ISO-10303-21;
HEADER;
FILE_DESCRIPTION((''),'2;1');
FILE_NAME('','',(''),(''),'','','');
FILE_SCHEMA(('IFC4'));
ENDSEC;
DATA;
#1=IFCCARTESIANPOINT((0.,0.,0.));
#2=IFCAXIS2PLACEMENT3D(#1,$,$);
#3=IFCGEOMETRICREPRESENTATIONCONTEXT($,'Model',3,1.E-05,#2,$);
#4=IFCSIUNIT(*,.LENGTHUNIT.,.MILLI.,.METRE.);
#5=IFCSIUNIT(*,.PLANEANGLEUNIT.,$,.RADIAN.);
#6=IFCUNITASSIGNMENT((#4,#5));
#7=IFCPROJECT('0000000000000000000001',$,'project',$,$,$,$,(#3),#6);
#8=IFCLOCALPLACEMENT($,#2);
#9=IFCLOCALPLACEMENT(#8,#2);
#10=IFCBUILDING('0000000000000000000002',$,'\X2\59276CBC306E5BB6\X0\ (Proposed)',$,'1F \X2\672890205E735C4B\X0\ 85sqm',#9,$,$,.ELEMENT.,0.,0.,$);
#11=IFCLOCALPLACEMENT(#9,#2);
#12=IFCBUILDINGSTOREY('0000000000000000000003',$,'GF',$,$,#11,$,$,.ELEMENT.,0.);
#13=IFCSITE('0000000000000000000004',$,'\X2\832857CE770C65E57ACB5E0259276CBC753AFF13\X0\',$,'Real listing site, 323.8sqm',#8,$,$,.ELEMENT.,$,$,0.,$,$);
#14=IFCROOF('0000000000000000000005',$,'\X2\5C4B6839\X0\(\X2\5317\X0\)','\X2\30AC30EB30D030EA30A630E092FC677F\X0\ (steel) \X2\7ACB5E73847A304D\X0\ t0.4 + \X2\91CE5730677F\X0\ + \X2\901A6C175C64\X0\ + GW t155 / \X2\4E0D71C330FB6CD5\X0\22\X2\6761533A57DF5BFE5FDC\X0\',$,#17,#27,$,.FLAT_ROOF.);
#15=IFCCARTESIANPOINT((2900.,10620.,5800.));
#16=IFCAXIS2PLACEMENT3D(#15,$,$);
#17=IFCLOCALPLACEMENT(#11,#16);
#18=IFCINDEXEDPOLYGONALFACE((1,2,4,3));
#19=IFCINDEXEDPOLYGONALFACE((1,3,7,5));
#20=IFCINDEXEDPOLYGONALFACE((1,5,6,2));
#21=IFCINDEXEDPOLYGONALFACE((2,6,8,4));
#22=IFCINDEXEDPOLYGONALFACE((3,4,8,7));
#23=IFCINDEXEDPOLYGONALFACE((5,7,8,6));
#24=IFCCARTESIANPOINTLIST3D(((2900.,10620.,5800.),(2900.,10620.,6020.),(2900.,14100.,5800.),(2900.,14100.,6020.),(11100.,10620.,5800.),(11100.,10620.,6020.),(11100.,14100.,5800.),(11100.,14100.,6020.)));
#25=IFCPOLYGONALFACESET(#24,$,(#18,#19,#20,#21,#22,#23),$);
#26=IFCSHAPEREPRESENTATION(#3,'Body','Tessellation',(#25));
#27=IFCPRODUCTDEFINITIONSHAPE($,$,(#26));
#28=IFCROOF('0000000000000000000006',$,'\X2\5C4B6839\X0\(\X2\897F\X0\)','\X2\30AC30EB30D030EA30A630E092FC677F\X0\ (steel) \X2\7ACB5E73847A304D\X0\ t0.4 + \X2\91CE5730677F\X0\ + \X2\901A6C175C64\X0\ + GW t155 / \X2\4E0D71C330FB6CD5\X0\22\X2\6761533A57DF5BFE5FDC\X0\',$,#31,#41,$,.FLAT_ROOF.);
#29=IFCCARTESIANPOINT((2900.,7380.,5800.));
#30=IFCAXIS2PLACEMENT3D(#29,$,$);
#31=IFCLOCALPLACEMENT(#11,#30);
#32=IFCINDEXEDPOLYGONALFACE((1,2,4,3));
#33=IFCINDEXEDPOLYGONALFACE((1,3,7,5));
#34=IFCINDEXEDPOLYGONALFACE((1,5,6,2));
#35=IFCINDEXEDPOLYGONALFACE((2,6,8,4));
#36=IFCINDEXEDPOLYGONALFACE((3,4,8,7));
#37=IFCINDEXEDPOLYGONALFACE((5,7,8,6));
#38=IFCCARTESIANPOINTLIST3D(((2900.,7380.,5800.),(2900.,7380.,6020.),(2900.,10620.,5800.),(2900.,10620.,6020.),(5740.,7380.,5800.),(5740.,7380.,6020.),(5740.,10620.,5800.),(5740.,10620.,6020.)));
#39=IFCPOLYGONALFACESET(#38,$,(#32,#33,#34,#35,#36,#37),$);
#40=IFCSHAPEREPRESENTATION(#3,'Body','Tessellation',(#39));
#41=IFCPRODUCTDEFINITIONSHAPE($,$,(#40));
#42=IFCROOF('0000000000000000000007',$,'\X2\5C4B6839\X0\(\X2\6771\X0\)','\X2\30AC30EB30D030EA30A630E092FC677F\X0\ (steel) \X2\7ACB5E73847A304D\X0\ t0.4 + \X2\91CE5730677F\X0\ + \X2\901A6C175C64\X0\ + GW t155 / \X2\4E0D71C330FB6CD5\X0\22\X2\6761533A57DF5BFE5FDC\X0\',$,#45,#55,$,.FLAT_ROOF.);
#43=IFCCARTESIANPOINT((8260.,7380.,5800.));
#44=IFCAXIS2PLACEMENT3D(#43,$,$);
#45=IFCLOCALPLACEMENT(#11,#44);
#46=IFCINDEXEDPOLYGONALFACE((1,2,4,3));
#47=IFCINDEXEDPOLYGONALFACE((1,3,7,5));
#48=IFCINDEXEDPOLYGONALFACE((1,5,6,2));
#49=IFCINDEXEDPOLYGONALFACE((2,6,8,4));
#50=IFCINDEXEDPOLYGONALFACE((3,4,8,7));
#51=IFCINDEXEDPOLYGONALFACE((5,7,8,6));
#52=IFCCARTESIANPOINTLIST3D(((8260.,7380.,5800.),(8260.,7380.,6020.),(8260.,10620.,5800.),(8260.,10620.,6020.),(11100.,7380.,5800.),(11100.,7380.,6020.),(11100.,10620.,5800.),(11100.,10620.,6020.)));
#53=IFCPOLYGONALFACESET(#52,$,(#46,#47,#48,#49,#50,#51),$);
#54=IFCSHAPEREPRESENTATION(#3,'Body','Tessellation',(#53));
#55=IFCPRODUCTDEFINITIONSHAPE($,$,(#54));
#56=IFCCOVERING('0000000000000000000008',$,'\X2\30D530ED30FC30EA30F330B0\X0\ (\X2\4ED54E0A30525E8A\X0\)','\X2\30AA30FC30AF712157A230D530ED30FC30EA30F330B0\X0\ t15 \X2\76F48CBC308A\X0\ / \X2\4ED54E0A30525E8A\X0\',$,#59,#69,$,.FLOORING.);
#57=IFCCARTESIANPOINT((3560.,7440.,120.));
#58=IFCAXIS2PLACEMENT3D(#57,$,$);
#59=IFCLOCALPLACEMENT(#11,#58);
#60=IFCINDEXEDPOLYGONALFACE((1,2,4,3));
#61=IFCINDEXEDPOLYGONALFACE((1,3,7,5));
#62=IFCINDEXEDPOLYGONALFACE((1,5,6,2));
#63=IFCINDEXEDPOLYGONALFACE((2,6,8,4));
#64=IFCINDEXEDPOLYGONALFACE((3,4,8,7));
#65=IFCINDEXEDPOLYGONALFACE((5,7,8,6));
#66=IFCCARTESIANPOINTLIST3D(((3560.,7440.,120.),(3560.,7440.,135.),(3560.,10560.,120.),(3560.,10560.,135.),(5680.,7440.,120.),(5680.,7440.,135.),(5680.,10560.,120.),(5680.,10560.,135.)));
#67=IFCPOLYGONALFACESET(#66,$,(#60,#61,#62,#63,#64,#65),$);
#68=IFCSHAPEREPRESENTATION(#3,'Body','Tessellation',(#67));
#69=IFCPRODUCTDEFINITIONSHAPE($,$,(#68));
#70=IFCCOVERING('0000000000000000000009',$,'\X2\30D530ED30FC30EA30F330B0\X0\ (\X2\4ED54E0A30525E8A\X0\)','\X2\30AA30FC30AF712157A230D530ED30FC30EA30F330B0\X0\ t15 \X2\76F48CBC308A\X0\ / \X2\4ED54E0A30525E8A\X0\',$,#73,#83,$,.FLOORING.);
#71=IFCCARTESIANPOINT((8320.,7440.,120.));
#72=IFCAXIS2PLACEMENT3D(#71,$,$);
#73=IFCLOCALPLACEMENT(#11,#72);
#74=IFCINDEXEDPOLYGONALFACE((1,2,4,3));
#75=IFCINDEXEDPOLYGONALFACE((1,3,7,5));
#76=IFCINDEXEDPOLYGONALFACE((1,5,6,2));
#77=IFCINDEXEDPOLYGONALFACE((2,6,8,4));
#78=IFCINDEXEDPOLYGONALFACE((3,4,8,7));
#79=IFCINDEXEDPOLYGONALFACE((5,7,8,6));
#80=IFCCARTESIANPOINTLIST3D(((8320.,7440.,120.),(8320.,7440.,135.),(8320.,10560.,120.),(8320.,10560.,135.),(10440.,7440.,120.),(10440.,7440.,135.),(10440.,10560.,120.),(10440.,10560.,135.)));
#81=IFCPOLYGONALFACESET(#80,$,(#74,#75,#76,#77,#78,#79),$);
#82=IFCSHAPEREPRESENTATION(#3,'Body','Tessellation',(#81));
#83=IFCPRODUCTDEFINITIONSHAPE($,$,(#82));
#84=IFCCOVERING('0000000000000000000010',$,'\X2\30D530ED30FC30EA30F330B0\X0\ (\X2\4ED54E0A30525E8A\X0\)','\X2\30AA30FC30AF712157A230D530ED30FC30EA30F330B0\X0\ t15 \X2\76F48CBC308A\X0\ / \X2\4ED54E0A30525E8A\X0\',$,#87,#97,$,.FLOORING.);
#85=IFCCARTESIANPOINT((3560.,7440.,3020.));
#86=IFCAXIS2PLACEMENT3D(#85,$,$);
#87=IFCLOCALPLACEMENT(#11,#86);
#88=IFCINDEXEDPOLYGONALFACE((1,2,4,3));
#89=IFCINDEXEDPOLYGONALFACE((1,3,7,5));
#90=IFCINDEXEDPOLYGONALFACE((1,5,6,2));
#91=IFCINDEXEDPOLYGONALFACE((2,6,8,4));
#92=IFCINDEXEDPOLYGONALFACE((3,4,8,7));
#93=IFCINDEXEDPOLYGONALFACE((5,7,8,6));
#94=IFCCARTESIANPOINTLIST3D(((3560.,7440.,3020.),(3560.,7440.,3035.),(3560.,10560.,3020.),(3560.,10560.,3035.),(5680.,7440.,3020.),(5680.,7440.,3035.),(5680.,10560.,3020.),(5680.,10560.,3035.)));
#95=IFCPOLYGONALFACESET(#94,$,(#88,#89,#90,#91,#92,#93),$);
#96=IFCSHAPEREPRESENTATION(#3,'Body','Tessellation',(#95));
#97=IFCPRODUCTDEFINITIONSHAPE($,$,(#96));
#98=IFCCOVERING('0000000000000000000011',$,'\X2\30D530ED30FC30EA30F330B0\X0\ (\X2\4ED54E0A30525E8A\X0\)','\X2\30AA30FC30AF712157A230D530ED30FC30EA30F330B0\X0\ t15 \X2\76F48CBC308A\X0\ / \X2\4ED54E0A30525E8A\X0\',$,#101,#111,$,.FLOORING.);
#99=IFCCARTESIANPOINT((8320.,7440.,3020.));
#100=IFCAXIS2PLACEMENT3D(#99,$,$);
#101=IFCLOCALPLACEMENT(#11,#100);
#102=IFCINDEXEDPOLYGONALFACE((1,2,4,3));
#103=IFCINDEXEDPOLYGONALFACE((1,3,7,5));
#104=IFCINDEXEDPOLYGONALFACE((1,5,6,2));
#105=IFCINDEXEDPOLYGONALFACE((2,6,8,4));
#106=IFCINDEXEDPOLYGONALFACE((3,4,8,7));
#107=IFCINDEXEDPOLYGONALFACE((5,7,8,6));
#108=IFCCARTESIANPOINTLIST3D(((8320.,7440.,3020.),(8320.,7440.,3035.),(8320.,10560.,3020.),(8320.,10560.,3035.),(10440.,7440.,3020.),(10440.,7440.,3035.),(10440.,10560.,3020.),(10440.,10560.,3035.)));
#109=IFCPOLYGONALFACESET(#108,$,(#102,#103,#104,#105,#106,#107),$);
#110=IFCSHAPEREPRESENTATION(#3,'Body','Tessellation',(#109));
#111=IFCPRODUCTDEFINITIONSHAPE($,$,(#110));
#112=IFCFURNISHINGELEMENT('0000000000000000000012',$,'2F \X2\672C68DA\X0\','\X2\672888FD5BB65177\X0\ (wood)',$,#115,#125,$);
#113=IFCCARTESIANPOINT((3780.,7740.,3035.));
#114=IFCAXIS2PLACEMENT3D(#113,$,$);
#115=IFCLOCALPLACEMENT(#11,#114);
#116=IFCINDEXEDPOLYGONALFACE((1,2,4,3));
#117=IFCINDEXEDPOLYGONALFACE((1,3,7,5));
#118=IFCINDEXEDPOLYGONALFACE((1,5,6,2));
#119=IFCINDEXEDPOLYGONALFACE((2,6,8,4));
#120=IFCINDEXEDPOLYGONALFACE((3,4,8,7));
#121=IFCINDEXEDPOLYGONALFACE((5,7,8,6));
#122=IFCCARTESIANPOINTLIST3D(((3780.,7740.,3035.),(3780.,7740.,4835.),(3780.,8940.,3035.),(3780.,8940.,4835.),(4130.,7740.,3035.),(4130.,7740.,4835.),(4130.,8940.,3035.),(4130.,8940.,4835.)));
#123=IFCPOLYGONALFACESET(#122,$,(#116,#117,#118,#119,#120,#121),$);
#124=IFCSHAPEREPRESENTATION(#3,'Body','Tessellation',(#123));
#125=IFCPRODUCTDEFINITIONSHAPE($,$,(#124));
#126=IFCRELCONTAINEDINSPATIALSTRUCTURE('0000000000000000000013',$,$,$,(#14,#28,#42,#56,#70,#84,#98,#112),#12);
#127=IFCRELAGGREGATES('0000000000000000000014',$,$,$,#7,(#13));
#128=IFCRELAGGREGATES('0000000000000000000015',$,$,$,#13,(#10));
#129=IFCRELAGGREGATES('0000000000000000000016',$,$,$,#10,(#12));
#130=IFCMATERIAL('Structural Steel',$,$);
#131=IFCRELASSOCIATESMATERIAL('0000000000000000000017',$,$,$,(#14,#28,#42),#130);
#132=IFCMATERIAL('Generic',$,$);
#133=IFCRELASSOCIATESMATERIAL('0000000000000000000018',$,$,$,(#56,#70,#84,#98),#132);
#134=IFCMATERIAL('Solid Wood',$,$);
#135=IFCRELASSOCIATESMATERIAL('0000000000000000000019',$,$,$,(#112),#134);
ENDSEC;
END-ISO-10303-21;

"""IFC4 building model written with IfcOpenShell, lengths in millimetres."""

from ifc_helpers import new_model, si_unit, frame, frame_2d, origin, place, context, project, spatial, rectangle, extrude, material, element, save


model = new_model("IFC4")

# Units and contexts
model_context = context("Model", 3, precision=1e-05, world=origin())
ifc_project = project(units=[si_unit("LENGTHUNIT", "METRE", prefix="MILLI"), si_unit("PLANEANGLEUNIT", "RADIAN")], contexts=[model_context])

# Site, building, storey
site_placement = place(None, origin())
site = spatial("IfcSite", under=ifc_project, at=site_placement, Name="茨城県日立市大沼町３", ObjectType="Real listing site, 323.8sqm", CompositionType="ELEMENT", RefElevation=0.0)
building_placement = place(site_placement, origin())
building = spatial("IfcBuilding", under=site, at=building_placement, Name="大沼の家 (Proposed)", ObjectType="1F 木造平屋 85sqm", CompositionType="ELEMENT", ElevationOfRefHeight=0.0, ElevationOfTerrain=0.0)
storey_placement = place(building_placement, origin())
storey = spatial("IfcBuildingStorey", under=building, at=storey_placement, Name="GF", CompositionType="ELEMENT", Elevation=0.0)

# Shared definitions
ifc_material_1 = material(Name="Solid Wood")

# Shared definitions
ifc_material_2 = material(Name="Generic")

# Roofs
ifc_material_3 = material(Name="Structural Steel")
roof_1_placement = place(storey_placement, frame((2900.0, 10620.0, 5800.0)))
element("IfcRoof", 1, at=roof_1_placement, inside=storey, material=ifc_material_3, Name="屋根(北)", Description="ガルバリウム鋼板 (steel) 立平葺き t0.4 + 野地板 + 通気層 + GW t155 / 不燃・法22条区域対応", PredefinedType="FLAT_ROOF", context=model_context, shape_type="SweptSolid", body=[
    extrude(rectangle(XDim=8200.0, YDim=3480.0, at=frame_2d((4100.0, 1740.0))), frame((2900.0, 10620.0, 5800.0)), (0.0, 0.0, 1.0), 220.0),
])
roof_2_placement = place(storey_placement, frame((2900.0, 7380.0, 5800.0)))
element("IfcRoof", 2, at=roof_2_placement, inside=storey, material=ifc_material_3, Name="屋根(西)", Description="ガルバリウム鋼板 (steel) 立平葺き t0.4 + 野地板 + 通気層 + GW t155 / 不燃・法22条区域対応", PredefinedType="FLAT_ROOF", context=model_context, shape_type="SweptSolid", body=[
    extrude(rectangle(XDim=2840.0, YDim=3240.0, at=frame_2d((1420.0, 1620.0))), frame((2900.0, 7380.0, 5800.0)), (0.0, 0.0, 1.0), 220.0),
])
roof_3_placement = place(storey_placement, frame((8260.0, 7380.0, 5800.0)))
element("IfcRoof", 3, at=roof_3_placement, inside=storey, material=ifc_material_3, Name="屋根(東)", Description="ガルバリウム鋼板 (steel) 立平葺き t0.4 + 野地板 + 通気層 + GW t155 / 不燃・法22条区域対応", PredefinedType="FLAT_ROOF", context=model_context, shape_type="SweptSolid", body=[
    extrude(rectangle(XDim=2840.0, YDim=3240.0, at=frame_2d((1420.0, 1620.0))), frame((8260.0, 7380.0, 5800.0)), (0.0, 0.0, 1.0), 220.0),
])

# Coverings
covering_1_placement = place(storey_placement, frame((3560.0, 7440.0, 120.0)))
element("IfcCovering", 4, at=covering_1_placement, inside=storey, material=ifc_material_2, Name="フローリング (仕上げ床)", Description="オーク無垢フローリング t15 直貼り / 仕上げ床", PredefinedType="FLOORING", context=model_context, shape_type="SweptSolid", body=[
    extrude(rectangle(XDim=2120.0, YDim=3120.0, at=frame_2d((1060.0, 1560.0))), frame((3560.0, 7440.0, 120.0)), (0.0, 0.0, 1.0), 15.0),
])
covering_2_placement = place(storey_placement, frame((8320.0, 7440.0, 120.0)))
element("IfcCovering", 5, at=covering_2_placement, inside=storey, material=ifc_material_2, Name="フローリング (仕上げ床)", Description="オーク無垢フローリング t15 直貼り / 仕上げ床", PredefinedType="FLOORING", context=model_context, shape_type="SweptSolid", body=[
    extrude(rectangle(XDim=2120.0, YDim=3120.0, at=frame_2d((1060.0, 1560.0))), frame((8320.0, 7440.0, 120.0)), (0.0, 0.0, 1.0), 15.0),
])
covering_3_placement = place(storey_placement, frame((3560.0, 7440.0, 3020.0)))
element("IfcCovering", 6, at=covering_3_placement, inside=storey, material=ifc_material_2, Name="フローリング (仕上げ床)", Description="オーク無垢フローリング t15 直貼り / 仕上げ床", PredefinedType="FLOORING", context=model_context, shape_type="SweptSolid", body=[
    extrude(rectangle(XDim=2120.0, YDim=3120.0, at=frame_2d((1060.0, 1560.0))), frame((3560.0, 7440.0, 3020.0)), (0.0, 0.0, 1.0), 15.0),
])
covering_4_placement = place(storey_placement, frame((8320.0, 7440.0, 3020.0)))
element("IfcCovering", 7, at=covering_4_placement, inside=storey, material=ifc_material_2, Name="フローリング (仕上げ床)", Description="オーク無垢フローリング t15 直貼り / 仕上げ床", PredefinedType="FLOORING", context=model_context, shape_type="SweptSolid", body=[
    extrude(rectangle(XDim=2120.0, YDim=3120.0, at=frame_2d((1060.0, 1560.0))), frame((8320.0, 7440.0, 3020.0)), (0.0, 0.0, 1.0), 15.0),
])

# Furnishing element
furnishing_placement = place(storey_placement, frame((3780.0, 7740.0, 3035.0)))
element("IfcFurnishingElement", 8, at=furnishing_placement, inside=storey, material=ifc_material_1, Name="2F 本棚", Description="木製家具 (wood)", context=model_context, shape_type="SweptSolid", body=[
    extrude(rectangle(XDim=350.0, YDim=1200.0, at=frame_2d((175.0, 600.0))), frame((3780.0, 7740.0, 3035.0)), (0.0, 0.0, 1.0), 1800.0),
])

save(model, "model.ifc")
